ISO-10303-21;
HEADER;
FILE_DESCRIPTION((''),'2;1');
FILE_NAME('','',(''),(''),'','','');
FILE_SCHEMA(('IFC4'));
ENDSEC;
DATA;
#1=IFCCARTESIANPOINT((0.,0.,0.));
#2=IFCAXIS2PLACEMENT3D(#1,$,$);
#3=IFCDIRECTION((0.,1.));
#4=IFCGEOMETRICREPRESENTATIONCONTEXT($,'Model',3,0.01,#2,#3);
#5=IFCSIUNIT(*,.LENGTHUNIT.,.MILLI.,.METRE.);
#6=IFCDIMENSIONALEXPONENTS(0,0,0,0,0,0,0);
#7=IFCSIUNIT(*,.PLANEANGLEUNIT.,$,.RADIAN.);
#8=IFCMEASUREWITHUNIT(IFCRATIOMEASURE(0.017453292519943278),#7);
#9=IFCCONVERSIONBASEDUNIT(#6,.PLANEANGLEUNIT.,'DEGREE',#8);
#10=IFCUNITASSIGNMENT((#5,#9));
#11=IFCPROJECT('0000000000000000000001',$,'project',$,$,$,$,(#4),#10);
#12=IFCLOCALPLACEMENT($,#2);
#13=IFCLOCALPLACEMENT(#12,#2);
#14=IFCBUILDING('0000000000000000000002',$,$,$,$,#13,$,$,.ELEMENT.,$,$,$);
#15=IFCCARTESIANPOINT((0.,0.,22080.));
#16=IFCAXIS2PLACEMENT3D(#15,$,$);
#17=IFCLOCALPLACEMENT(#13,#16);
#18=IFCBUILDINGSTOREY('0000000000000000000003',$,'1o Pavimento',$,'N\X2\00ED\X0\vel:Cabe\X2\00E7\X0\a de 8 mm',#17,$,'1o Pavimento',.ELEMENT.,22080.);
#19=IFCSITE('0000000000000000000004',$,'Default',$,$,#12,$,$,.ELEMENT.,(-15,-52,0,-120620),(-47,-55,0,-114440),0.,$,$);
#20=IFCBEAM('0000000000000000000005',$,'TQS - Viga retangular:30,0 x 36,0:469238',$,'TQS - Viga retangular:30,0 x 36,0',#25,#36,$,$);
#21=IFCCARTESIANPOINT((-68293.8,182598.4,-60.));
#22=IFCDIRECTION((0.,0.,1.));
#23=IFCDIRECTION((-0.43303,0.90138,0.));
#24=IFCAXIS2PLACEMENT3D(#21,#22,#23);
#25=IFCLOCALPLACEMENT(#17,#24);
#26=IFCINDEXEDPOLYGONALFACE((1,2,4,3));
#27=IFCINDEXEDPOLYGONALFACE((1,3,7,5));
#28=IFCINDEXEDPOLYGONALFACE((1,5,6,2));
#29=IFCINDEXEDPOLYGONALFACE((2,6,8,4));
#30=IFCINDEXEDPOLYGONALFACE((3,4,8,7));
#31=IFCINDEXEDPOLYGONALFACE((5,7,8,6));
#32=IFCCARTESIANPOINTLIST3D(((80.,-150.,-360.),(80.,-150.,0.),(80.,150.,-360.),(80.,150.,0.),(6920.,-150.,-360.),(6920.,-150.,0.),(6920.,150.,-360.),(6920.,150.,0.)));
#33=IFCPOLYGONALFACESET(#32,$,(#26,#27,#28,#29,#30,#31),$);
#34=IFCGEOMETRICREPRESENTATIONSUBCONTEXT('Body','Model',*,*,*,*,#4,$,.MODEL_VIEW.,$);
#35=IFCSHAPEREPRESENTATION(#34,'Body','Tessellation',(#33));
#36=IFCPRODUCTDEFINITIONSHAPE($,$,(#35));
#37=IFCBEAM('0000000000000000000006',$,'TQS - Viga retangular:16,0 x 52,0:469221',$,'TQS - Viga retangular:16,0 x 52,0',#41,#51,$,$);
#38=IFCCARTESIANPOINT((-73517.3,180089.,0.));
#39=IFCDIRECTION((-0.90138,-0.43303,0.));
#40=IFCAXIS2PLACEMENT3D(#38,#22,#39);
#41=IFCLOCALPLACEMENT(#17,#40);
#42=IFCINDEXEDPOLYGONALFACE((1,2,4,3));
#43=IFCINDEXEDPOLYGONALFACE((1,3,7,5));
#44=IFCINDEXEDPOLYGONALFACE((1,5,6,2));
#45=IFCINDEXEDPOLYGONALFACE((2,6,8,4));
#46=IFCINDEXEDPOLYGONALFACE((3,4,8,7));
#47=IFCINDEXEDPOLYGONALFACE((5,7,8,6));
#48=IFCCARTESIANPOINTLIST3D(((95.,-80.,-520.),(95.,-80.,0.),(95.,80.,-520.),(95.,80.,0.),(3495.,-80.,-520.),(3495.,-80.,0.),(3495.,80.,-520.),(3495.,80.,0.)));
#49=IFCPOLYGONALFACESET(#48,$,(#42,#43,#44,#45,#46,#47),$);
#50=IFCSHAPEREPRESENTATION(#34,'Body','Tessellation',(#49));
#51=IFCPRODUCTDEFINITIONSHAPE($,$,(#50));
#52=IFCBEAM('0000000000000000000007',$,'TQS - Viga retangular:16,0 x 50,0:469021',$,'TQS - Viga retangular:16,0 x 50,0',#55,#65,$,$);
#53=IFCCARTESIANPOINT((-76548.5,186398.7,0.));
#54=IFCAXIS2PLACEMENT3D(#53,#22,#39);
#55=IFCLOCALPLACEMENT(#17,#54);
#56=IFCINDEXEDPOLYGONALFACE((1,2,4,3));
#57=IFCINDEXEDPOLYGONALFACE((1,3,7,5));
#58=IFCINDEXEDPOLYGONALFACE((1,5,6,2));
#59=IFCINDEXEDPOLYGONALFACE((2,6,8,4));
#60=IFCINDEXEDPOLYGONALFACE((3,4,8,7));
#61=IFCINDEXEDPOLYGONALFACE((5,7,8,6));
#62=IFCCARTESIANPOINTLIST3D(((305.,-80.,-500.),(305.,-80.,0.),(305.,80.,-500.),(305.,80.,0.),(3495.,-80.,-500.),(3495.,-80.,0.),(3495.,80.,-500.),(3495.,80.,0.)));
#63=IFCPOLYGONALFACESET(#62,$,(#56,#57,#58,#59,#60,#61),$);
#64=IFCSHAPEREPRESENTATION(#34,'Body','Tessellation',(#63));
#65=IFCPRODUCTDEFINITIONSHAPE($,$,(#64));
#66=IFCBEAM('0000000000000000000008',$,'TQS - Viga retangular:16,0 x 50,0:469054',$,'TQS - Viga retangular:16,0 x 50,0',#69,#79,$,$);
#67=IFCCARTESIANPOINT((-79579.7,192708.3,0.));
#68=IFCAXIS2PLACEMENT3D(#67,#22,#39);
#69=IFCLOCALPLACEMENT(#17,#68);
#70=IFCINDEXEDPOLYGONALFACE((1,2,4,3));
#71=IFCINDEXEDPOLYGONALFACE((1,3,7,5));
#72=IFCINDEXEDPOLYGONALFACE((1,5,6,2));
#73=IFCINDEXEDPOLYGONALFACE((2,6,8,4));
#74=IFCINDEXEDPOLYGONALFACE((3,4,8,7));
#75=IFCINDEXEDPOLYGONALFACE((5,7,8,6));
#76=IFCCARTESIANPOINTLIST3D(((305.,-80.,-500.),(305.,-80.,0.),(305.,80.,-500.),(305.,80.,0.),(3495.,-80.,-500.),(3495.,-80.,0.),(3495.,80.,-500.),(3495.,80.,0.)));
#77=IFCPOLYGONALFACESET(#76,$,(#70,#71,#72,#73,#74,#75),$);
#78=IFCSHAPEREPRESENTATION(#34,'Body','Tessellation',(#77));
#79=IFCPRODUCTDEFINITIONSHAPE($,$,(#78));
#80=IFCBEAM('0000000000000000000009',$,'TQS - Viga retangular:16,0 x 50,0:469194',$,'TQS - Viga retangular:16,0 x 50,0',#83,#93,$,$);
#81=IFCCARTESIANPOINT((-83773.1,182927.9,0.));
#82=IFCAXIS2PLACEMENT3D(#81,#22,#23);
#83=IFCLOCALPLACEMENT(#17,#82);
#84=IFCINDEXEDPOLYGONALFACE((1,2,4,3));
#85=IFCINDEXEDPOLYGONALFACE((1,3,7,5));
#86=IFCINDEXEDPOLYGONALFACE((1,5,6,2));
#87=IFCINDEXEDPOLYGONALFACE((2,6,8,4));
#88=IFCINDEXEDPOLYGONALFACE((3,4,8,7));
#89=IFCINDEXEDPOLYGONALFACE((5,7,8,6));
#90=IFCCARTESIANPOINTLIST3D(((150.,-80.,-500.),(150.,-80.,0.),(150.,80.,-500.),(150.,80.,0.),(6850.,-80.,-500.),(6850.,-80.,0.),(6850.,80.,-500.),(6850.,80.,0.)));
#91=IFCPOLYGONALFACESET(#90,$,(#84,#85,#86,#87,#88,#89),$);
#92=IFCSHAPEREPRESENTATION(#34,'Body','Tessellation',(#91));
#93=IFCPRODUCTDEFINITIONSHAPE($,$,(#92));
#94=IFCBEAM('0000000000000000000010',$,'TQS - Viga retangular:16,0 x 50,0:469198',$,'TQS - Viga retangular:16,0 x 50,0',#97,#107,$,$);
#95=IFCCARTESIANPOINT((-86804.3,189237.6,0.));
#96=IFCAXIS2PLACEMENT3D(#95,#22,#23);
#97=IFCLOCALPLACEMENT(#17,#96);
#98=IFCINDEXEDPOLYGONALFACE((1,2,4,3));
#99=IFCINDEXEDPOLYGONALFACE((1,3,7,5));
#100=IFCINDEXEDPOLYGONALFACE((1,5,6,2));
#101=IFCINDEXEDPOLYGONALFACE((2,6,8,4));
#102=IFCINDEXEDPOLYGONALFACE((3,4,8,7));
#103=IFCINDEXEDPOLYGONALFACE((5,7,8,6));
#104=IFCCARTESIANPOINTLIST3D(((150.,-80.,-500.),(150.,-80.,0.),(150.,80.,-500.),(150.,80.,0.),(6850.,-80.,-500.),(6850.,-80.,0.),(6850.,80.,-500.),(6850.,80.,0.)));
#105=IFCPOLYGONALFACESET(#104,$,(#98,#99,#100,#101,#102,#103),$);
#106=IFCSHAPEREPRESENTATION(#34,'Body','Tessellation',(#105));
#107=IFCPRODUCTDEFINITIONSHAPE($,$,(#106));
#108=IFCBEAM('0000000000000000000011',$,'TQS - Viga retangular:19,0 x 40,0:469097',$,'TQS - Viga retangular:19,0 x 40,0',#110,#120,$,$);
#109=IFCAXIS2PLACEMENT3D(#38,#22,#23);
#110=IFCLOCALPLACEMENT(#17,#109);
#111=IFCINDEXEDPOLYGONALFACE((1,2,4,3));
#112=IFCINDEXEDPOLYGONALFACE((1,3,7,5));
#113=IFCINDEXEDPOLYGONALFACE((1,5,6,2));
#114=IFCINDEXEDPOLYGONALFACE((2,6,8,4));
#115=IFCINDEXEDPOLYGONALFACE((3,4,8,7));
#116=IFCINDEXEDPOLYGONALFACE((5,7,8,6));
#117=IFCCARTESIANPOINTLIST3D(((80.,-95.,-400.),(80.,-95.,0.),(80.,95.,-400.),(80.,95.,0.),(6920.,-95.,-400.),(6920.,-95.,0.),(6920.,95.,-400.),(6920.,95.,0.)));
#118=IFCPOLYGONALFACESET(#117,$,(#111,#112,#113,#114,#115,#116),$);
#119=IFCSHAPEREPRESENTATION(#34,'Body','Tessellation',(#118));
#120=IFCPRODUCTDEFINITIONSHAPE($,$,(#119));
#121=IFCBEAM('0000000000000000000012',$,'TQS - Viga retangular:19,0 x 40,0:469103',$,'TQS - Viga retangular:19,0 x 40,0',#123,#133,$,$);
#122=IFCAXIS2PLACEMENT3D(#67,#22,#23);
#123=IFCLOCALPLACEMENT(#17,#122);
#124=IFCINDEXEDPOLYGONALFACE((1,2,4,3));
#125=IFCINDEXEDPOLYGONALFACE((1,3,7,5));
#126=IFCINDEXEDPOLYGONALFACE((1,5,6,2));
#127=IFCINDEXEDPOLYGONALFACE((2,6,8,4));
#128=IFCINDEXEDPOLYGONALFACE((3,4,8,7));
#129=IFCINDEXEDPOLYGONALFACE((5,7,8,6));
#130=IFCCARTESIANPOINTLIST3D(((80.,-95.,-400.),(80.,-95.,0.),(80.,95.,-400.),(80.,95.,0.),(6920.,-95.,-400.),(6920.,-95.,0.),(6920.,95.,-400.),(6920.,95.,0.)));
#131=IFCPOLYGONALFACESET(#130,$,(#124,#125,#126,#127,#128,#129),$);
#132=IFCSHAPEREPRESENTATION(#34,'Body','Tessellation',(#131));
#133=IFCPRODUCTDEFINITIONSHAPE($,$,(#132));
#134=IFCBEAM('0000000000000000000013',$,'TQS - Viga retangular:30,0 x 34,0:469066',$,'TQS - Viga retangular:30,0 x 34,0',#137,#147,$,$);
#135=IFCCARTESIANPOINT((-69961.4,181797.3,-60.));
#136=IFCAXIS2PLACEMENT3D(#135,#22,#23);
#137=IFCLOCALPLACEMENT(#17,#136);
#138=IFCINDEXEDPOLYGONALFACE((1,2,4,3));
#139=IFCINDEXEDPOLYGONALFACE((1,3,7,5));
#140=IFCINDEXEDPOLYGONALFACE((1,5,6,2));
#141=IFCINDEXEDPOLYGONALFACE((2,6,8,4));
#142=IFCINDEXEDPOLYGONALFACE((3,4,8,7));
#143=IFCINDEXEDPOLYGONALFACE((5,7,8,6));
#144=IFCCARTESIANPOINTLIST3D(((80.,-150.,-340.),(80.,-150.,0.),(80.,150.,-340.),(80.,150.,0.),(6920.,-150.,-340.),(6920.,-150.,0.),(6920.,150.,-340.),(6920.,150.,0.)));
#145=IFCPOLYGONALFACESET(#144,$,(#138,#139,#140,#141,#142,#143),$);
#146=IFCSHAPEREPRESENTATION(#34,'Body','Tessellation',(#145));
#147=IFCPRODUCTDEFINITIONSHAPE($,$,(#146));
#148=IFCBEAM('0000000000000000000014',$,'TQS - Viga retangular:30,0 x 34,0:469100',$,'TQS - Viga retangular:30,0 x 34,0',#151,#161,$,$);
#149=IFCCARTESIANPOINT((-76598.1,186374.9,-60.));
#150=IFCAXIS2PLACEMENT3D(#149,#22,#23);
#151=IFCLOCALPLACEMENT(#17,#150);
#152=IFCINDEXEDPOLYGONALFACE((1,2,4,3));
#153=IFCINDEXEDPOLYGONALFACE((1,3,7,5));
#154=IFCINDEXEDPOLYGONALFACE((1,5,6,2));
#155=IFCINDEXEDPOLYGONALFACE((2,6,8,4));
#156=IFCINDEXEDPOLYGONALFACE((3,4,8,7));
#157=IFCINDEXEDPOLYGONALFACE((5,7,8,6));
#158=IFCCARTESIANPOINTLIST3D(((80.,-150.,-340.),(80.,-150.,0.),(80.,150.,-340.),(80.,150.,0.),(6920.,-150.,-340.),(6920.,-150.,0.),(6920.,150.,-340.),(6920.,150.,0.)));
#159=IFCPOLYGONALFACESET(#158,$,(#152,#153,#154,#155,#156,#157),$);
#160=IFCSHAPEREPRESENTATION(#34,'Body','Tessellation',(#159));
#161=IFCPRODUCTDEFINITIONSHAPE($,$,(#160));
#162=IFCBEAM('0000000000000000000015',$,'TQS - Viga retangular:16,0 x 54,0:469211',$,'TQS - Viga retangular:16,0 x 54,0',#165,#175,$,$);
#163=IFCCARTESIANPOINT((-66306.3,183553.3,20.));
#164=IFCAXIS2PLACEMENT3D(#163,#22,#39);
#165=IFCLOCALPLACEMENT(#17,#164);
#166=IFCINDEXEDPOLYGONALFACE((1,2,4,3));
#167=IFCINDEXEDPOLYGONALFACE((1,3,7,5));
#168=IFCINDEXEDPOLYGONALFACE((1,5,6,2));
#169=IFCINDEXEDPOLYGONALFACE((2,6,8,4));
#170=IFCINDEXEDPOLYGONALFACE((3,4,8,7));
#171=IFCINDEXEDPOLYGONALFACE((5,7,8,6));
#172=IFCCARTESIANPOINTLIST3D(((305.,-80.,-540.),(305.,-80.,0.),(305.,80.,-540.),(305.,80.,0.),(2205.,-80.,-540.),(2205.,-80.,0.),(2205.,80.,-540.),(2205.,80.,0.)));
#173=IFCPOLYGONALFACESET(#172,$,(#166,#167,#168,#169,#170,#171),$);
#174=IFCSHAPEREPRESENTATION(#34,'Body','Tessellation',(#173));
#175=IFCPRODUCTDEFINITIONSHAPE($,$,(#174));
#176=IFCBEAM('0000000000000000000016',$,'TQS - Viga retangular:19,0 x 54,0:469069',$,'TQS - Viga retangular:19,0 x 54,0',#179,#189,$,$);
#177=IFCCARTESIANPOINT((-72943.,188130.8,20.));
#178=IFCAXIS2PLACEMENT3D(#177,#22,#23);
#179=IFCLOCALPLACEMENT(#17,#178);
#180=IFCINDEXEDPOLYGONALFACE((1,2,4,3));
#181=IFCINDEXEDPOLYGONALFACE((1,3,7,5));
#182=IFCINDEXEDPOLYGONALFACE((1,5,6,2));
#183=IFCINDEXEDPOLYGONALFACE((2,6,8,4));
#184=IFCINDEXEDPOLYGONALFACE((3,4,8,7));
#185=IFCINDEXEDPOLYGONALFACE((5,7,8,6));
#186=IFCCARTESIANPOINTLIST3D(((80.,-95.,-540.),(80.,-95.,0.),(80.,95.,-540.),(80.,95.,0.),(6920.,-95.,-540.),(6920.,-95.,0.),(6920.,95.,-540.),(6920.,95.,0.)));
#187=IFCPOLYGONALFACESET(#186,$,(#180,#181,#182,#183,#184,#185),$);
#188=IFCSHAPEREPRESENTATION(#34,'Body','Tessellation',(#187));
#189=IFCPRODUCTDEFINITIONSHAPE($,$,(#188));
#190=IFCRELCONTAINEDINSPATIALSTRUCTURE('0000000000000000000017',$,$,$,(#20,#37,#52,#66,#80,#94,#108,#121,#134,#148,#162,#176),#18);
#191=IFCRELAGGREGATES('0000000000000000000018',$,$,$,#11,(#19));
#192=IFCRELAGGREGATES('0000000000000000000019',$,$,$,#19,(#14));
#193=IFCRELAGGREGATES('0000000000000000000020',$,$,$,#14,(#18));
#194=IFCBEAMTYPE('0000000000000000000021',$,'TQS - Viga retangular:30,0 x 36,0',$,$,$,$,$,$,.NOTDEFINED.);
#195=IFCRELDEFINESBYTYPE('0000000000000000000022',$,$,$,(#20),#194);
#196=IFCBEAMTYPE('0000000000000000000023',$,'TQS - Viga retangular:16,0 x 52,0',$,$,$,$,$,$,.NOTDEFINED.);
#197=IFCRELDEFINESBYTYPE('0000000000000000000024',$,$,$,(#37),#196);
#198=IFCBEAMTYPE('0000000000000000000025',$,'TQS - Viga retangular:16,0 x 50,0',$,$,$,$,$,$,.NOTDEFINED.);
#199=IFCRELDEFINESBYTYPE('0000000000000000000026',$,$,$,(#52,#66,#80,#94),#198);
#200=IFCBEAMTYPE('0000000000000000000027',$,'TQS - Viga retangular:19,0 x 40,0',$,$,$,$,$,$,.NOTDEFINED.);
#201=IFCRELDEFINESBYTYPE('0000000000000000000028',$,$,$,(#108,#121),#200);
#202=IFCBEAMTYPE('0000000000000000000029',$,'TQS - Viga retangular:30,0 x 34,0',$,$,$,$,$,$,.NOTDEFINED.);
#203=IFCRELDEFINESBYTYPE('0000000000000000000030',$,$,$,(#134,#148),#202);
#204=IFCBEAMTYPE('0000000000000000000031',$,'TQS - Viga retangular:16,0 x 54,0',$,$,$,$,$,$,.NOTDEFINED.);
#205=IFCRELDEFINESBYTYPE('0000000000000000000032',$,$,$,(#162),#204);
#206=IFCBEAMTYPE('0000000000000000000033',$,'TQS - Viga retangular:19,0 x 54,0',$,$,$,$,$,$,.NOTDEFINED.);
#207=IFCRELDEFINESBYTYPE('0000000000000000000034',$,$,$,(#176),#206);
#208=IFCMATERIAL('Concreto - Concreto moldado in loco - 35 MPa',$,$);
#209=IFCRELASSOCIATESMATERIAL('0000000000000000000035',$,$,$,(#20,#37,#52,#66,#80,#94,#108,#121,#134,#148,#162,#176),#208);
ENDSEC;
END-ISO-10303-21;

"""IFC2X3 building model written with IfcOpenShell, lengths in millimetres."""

from ifc_helpers import new_model, entity, si_unit, converted_unit, direction, frame, frame_2d, origin, origin_2d_with_axis, place, context, subcontext, project, spatial, rectangle, extrude, material, type_object, element, save


model = new_model("IFC2X3")

# Units and contexts
model_context = context("Model", 3, precision=0.01, world=origin(), true_north=direction((0.0, 1.0)))
body_context = subcontext(model_context, "Body", "Model", "MODEL_VIEW")
ifc_project = project(units=[si_unit("LENGTHUNIT", "METRE", prefix="MILLI"), converted_unit("PLANEANGLEUNIT", "DEGREE", entity("IfcRatioMeasure", 0.017453292519943278), si_unit("PLANEANGLEUNIT", "RADIAN"), dimensions=[0, 0, 0, 0, 0, 0, 0])], contexts=[model_context])

# Site, building, storey
site_placement = place(None, origin())
site = spatial("IfcSite", under=ifc_project, at=site_placement, Name="Default", CompositionType="ELEMENT", RefLatitude=(-15, -52, 0, -120620), RefLongitude=(-47, -55, 0, -114440), RefElevation=0.0)
building_placement = place(site_placement, origin())
building = spatial("IfcBuilding", under=site, at=building_placement, CompositionType="ELEMENT")
storey_placement = place(building_placement, frame((0.0, 0.0, 22080.0)))
storey = spatial("IfcBuildingStorey", under=building, at=storey_placement, Name="1o Pavimento", ObjectType="Nível:Cabeça de 8 mm", LongName="1o Pavimento", CompositionType="ELEMENT", Elevation=22080.0)

# Beams
ifc_material_1 = material(Name="Concreto - Concreto moldado in loco - 35 MPa")
beam_type_1 = type_object("IfcBeamType", Name="TQS - Viga retangular:30,0 x 36,0", PredefinedType="NOTDEFINED")
beam_1_placement = place(storey_placement, frame((-68293.8, 182598.4, -60.0), z_axis=(0.0, 0.0, 1.0), x_axis=(-0.43303, 0.90138, 0.0)))
element("IfcBeam", 1, at=beam_1_placement, inside=storey, type_object=beam_type_1, material=ifc_material_1, Name="TQS - Viga retangular:30,0 x 36,0:469238", ObjectType="TQS - Viga retangular:30,0 x 36,0", context=body_context, shape_type="SweptSolid", body=[
    extrude(rectangle(XDim=360.0, YDim=300.0, at=frame_2d((0.0, 0.0), x_axis=(1.0, 0.0))), frame((80.0, 0.0, -180.0), z_axis=(1.0, 0.0, 0.0), x_axis=(0.0, 0.0, -1.0)), (0.0, 0.0, 1.0), 6840.0),
])
beam_type_2 = type_object("IfcBeamType", Name="TQS - Viga retangular:16,0 x 52,0", PredefinedType="NOTDEFINED")
beam_2_placement = place(storey_placement, frame((-73517.3, 180089.0, 0.0), z_axis=(0.0, 0.0, 1.0), x_axis=(-0.90138, -0.43303, 0.0)))
element("IfcBeam", 2, at=beam_2_placement, inside=storey, type_object=beam_type_2, material=ifc_material_1, Name="TQS - Viga retangular:16,0 x 52,0:469221", ObjectType="TQS - Viga retangular:16,0 x 52,0", context=body_context, shape_type="SweptSolid", body=[
    extrude(rectangle(XDim=520.0, YDim=160.0, at=frame_2d((0.0, 0.0), x_axis=(1.0, 0.0))), frame((95.0, 0.0, -260.0), z_axis=(1.0, 0.0, 0.0), x_axis=(0.0, 0.0, -1.0)), (0.0, 0.0, 1.0), 3400.0),
])
beam_type_3 = type_object("IfcBeamType", Name="TQS - Viga retangular:16,0 x 50,0", PredefinedType="NOTDEFINED")
beam_3_placement = place(storey_placement, frame((-76548.5, 186398.7, 0.0), z_axis=(0.0, 0.0, 1.0), x_axis=(-0.90138, -0.43303, 0.0)))
element("IfcBeam", 3, at=beam_3_placement, inside=storey, type_object=beam_type_3, material=ifc_material_1, Name="TQS - Viga retangular:16,0 x 50,0:469021", ObjectType="TQS - Viga retangular:16,0 x 50,0", context=body_context, shape_type="SweptSolid", body=[
    extrude(rectangle(XDim=500.0, YDim=160.0, at=frame_2d((0.0, 0.0), x_axis=(1.0, 0.0))), frame((305.0, 0.0, -250.0), z_axis=(1.0, 0.0, 0.0), x_axis=(0.0, 0.0, -1.0)), (0.0, 0.0, 1.0), 3190.0),
])
beam_4_placement = place(storey_placement, frame((-79579.7, 192708.3, 0.0), z_axis=(0.0, 0.0, 1.0), x_axis=(-0.90138, -0.43303, 0.0)))
element("IfcBeam", 4, at=beam_4_placement, inside=storey, type_object=beam_type_3, material=ifc_material_1, Name="TQS - Viga retangular:16,0 x 50,0:469054", ObjectType="TQS - Viga retangular:16,0 x 50,0", context=body_context, shape_type="SweptSolid", body=[
    extrude(rectangle(XDim=500.0, YDim=160.0, at=frame_2d((0.0, 0.0), x_axis=(1.0, 0.0))), frame((305.0, 0.0, -250.0), z_axis=(1.0, 0.0, 0.0), x_axis=(0.0, 0.0, -1.0)), (0.0, 0.0, 1.0), 3190.0),
])
beam_5_placement = place(storey_placement, frame((-83773.1, 182927.9, 0.0), z_axis=(0.0, 0.0, 1.0), x_axis=(-0.43303, 0.90138, 0.0)))
element("IfcBeam", 5, at=beam_5_placement, inside=storey, type_object=beam_type_3, material=ifc_material_1, Name="TQS - Viga retangular:16,0 x 50,0:469194", ObjectType="TQS - Viga retangular:16,0 x 50,0", context=body_context, shape_type="SweptSolid", body=[
    extrude(rectangle(XDim=500.0, YDim=160.0, at=origin_2d_with_axis()), frame((150.0, 0.0, -250.0), z_axis=(1.0, 0.0, 0.0), x_axis=(0.0, 0.0, -1.0)), (0.0, 0.0, 1.0), 6700.0),
])
beam_6_placement = place(storey_placement, frame((-86804.3, 189237.6, 0.0), z_axis=(0.0, 0.0, 1.0), x_axis=(-0.43303, 0.90138, 0.0)))
element("IfcBeam", 6, at=beam_6_placement, inside=storey, type_object=beam_type_3, material=ifc_material_1, Name="TQS - Viga retangular:16,0 x 50,0:469198", ObjectType="TQS - Viga retangular:16,0 x 50,0", context=body_context, shape_type="SweptSolid", body=[
    extrude(rectangle(XDim=500.0, YDim=160.0, at=origin_2d_with_axis()), frame((150.0, 0.0, -250.0), z_axis=(1.0, 0.0, 0.0), x_axis=(0.0, 0.0, -1.0)), (0.0, 0.0, 1.0), 6700.0),
])
beam_type_4 = type_object("IfcBeamType", Name="TQS - Viga retangular:19,0 x 40,0", PredefinedType="NOTDEFINED")
beam_7_placement = place(storey_placement, frame((-73517.3, 180089.0, 0.0), z_axis=(0.0, 0.0, 1.0), x_axis=(-0.43303, 0.90138, 0.0)))
element("IfcBeam", 7, at=beam_7_placement, inside=storey, type_object=beam_type_4, material=ifc_material_1, Name="TQS - Viga retangular:19,0 x 40,0:469097", ObjectType="TQS - Viga retangular:19,0 x 40,0", context=body_context, shape_type="SweptSolid", body=[
    extrude(rectangle(XDim=400.0, YDim=190.0, at=frame_2d((0.0, 0.0), x_axis=(1.0, 0.0))), frame((80.0, 0.0, -200.0), z_axis=(1.0, 0.0, 0.0), x_axis=(0.0, 0.0, -1.0)), (0.0, 0.0, 1.0), 6840.0),
])
beam_8_placement = place(storey_placement, frame((-79579.7, 192708.3, 0.0), z_axis=(0.0, 0.0, 1.0), x_axis=(-0.43303, 0.90138, 0.0)))
element("IfcBeam", 8, at=beam_8_placement, inside=storey, type_object=beam_type_4, material=ifc_material_1, Name="TQS - Viga retangular:19,0 x 40,0:469103", ObjectType="TQS - Viga retangular:19,0 x 40,0", context=body_context, shape_type="SweptSolid", body=[
    extrude(rectangle(XDim=400.0, YDim=190.0, at=frame_2d((0.0, 0.0), x_axis=(1.0, 0.0))), frame((80.0, 0.0, -200.0), z_axis=(1.0, 0.0, 0.0), x_axis=(0.0, 0.0, -1.0)), (0.0, 0.0, 1.0), 6840.0),
])
beam_type_5 = type_object("IfcBeamType", Name="TQS - Viga retangular:30,0 x 34,0", PredefinedType="NOTDEFINED")
beam_9_placement = place(storey_placement, frame((-69961.4, 181797.3, -60.0), z_axis=(0.0, 0.0, 1.0), x_axis=(-0.43303, 0.90138, 0.0)))
element("IfcBeam", 9, at=beam_9_placement, inside=storey, type_object=beam_type_5, material=ifc_material_1, Name="TQS - Viga retangular:30,0 x 34,0:469066", ObjectType="TQS - Viga retangular:30,0 x 34,0", context=body_context, shape_type="SweptSolid", body=[
    extrude(rectangle(XDim=340.0, YDim=300.0, at=frame_2d((0.0, 0.0), x_axis=(1.0, 0.0))), frame((80.0, 0.0, -170.0), z_axis=(1.0, 0.0, 0.0), x_axis=(0.0, 0.0, -1.0)), (0.0, 0.0, 1.0), 6840.0),
])
beam_10_placement = place(storey_placement, frame((-76598.1, 186374.9, -60.0), z_axis=(0.0, 0.0, 1.0), x_axis=(-0.43303, 0.90138, 0.0)))
element("IfcBeam", 10, at=beam_10_placement, inside=storey, type_object=beam_type_5, material=ifc_material_1, Name="TQS - Viga retangular:30,0 x 34,0:469100", ObjectType="TQS - Viga retangular:30,0 x 34,0", context=body_context, shape_type="SweptSolid", body=[
    extrude(rectangle(XDim=340.0, YDim=300.0, at=frame_2d((0.0, 0.0), x_axis=(1.0, 0.0))), frame((80.0, 0.0, -170.0), z_axis=(1.0, 0.0, 0.0), x_axis=(0.0, 0.0, -1.0)), (0.0, 0.0, 1.0), 6840.0),
])
beam_type_6 = type_object("IfcBeamType", Name="TQS - Viga retangular:16,0 x 54,0", PredefinedType="NOTDEFINED")
beam_11_placement = place(storey_placement, frame((-66306.3, 183553.3, 20.0), z_axis=(0.0, 0.0, 1.0), x_axis=(-0.90138, -0.43303, 0.0)))
element("IfcBeam", 11, at=beam_11_placement, inside=storey, type_object=beam_type_6, material=ifc_material_1, Name="TQS - Viga retangular:16,0 x 54,0:469211", ObjectType="TQS - Viga retangular:16,0 x 54,0", context=body_context, shape_type="SweptSolid", body=[
    extrude(rectangle(XDim=540.0, YDim=160.0, at=origin_2d_with_axis()), frame((305.0, 0.0, -270.0), z_axis=(1.0, 0.0, 0.0), x_axis=(0.0, 0.0, -1.0)), (0.0, 0.0, 1.0), 1900.0),
])
beam_type_7 = type_object("IfcBeamType", Name="TQS - Viga retangular:19,0 x 54,0", PredefinedType="NOTDEFINED")
beam_12_placement = place(storey_placement, frame((-72943.0, 188130.8, 20.0), z_axis=(0.0, 0.0, 1.0), x_axis=(-0.43303, 0.90138, 0.0)))
element("IfcBeam", 12, at=beam_12_placement, inside=storey, type_object=beam_type_7, material=ifc_material_1, Name="TQS - Viga retangular:19,0 x 54,0:469069", ObjectType="TQS - Viga retangular:19,0 x 54,0", context=body_context, shape_type="SweptSolid", body=[
    extrude(rectangle(XDim=540.0, YDim=190.0, at=frame_2d((0.0, 0.0), x_axis=(1.0, 0.0))), frame((80.0, 0.0, -270.0), z_axis=(1.0, 0.0, 0.0), x_axis=(0.0, 0.0, -1.0)), (0.0, 0.0, 1.0), 6840.0),
])

save(model, "model.ifc")
